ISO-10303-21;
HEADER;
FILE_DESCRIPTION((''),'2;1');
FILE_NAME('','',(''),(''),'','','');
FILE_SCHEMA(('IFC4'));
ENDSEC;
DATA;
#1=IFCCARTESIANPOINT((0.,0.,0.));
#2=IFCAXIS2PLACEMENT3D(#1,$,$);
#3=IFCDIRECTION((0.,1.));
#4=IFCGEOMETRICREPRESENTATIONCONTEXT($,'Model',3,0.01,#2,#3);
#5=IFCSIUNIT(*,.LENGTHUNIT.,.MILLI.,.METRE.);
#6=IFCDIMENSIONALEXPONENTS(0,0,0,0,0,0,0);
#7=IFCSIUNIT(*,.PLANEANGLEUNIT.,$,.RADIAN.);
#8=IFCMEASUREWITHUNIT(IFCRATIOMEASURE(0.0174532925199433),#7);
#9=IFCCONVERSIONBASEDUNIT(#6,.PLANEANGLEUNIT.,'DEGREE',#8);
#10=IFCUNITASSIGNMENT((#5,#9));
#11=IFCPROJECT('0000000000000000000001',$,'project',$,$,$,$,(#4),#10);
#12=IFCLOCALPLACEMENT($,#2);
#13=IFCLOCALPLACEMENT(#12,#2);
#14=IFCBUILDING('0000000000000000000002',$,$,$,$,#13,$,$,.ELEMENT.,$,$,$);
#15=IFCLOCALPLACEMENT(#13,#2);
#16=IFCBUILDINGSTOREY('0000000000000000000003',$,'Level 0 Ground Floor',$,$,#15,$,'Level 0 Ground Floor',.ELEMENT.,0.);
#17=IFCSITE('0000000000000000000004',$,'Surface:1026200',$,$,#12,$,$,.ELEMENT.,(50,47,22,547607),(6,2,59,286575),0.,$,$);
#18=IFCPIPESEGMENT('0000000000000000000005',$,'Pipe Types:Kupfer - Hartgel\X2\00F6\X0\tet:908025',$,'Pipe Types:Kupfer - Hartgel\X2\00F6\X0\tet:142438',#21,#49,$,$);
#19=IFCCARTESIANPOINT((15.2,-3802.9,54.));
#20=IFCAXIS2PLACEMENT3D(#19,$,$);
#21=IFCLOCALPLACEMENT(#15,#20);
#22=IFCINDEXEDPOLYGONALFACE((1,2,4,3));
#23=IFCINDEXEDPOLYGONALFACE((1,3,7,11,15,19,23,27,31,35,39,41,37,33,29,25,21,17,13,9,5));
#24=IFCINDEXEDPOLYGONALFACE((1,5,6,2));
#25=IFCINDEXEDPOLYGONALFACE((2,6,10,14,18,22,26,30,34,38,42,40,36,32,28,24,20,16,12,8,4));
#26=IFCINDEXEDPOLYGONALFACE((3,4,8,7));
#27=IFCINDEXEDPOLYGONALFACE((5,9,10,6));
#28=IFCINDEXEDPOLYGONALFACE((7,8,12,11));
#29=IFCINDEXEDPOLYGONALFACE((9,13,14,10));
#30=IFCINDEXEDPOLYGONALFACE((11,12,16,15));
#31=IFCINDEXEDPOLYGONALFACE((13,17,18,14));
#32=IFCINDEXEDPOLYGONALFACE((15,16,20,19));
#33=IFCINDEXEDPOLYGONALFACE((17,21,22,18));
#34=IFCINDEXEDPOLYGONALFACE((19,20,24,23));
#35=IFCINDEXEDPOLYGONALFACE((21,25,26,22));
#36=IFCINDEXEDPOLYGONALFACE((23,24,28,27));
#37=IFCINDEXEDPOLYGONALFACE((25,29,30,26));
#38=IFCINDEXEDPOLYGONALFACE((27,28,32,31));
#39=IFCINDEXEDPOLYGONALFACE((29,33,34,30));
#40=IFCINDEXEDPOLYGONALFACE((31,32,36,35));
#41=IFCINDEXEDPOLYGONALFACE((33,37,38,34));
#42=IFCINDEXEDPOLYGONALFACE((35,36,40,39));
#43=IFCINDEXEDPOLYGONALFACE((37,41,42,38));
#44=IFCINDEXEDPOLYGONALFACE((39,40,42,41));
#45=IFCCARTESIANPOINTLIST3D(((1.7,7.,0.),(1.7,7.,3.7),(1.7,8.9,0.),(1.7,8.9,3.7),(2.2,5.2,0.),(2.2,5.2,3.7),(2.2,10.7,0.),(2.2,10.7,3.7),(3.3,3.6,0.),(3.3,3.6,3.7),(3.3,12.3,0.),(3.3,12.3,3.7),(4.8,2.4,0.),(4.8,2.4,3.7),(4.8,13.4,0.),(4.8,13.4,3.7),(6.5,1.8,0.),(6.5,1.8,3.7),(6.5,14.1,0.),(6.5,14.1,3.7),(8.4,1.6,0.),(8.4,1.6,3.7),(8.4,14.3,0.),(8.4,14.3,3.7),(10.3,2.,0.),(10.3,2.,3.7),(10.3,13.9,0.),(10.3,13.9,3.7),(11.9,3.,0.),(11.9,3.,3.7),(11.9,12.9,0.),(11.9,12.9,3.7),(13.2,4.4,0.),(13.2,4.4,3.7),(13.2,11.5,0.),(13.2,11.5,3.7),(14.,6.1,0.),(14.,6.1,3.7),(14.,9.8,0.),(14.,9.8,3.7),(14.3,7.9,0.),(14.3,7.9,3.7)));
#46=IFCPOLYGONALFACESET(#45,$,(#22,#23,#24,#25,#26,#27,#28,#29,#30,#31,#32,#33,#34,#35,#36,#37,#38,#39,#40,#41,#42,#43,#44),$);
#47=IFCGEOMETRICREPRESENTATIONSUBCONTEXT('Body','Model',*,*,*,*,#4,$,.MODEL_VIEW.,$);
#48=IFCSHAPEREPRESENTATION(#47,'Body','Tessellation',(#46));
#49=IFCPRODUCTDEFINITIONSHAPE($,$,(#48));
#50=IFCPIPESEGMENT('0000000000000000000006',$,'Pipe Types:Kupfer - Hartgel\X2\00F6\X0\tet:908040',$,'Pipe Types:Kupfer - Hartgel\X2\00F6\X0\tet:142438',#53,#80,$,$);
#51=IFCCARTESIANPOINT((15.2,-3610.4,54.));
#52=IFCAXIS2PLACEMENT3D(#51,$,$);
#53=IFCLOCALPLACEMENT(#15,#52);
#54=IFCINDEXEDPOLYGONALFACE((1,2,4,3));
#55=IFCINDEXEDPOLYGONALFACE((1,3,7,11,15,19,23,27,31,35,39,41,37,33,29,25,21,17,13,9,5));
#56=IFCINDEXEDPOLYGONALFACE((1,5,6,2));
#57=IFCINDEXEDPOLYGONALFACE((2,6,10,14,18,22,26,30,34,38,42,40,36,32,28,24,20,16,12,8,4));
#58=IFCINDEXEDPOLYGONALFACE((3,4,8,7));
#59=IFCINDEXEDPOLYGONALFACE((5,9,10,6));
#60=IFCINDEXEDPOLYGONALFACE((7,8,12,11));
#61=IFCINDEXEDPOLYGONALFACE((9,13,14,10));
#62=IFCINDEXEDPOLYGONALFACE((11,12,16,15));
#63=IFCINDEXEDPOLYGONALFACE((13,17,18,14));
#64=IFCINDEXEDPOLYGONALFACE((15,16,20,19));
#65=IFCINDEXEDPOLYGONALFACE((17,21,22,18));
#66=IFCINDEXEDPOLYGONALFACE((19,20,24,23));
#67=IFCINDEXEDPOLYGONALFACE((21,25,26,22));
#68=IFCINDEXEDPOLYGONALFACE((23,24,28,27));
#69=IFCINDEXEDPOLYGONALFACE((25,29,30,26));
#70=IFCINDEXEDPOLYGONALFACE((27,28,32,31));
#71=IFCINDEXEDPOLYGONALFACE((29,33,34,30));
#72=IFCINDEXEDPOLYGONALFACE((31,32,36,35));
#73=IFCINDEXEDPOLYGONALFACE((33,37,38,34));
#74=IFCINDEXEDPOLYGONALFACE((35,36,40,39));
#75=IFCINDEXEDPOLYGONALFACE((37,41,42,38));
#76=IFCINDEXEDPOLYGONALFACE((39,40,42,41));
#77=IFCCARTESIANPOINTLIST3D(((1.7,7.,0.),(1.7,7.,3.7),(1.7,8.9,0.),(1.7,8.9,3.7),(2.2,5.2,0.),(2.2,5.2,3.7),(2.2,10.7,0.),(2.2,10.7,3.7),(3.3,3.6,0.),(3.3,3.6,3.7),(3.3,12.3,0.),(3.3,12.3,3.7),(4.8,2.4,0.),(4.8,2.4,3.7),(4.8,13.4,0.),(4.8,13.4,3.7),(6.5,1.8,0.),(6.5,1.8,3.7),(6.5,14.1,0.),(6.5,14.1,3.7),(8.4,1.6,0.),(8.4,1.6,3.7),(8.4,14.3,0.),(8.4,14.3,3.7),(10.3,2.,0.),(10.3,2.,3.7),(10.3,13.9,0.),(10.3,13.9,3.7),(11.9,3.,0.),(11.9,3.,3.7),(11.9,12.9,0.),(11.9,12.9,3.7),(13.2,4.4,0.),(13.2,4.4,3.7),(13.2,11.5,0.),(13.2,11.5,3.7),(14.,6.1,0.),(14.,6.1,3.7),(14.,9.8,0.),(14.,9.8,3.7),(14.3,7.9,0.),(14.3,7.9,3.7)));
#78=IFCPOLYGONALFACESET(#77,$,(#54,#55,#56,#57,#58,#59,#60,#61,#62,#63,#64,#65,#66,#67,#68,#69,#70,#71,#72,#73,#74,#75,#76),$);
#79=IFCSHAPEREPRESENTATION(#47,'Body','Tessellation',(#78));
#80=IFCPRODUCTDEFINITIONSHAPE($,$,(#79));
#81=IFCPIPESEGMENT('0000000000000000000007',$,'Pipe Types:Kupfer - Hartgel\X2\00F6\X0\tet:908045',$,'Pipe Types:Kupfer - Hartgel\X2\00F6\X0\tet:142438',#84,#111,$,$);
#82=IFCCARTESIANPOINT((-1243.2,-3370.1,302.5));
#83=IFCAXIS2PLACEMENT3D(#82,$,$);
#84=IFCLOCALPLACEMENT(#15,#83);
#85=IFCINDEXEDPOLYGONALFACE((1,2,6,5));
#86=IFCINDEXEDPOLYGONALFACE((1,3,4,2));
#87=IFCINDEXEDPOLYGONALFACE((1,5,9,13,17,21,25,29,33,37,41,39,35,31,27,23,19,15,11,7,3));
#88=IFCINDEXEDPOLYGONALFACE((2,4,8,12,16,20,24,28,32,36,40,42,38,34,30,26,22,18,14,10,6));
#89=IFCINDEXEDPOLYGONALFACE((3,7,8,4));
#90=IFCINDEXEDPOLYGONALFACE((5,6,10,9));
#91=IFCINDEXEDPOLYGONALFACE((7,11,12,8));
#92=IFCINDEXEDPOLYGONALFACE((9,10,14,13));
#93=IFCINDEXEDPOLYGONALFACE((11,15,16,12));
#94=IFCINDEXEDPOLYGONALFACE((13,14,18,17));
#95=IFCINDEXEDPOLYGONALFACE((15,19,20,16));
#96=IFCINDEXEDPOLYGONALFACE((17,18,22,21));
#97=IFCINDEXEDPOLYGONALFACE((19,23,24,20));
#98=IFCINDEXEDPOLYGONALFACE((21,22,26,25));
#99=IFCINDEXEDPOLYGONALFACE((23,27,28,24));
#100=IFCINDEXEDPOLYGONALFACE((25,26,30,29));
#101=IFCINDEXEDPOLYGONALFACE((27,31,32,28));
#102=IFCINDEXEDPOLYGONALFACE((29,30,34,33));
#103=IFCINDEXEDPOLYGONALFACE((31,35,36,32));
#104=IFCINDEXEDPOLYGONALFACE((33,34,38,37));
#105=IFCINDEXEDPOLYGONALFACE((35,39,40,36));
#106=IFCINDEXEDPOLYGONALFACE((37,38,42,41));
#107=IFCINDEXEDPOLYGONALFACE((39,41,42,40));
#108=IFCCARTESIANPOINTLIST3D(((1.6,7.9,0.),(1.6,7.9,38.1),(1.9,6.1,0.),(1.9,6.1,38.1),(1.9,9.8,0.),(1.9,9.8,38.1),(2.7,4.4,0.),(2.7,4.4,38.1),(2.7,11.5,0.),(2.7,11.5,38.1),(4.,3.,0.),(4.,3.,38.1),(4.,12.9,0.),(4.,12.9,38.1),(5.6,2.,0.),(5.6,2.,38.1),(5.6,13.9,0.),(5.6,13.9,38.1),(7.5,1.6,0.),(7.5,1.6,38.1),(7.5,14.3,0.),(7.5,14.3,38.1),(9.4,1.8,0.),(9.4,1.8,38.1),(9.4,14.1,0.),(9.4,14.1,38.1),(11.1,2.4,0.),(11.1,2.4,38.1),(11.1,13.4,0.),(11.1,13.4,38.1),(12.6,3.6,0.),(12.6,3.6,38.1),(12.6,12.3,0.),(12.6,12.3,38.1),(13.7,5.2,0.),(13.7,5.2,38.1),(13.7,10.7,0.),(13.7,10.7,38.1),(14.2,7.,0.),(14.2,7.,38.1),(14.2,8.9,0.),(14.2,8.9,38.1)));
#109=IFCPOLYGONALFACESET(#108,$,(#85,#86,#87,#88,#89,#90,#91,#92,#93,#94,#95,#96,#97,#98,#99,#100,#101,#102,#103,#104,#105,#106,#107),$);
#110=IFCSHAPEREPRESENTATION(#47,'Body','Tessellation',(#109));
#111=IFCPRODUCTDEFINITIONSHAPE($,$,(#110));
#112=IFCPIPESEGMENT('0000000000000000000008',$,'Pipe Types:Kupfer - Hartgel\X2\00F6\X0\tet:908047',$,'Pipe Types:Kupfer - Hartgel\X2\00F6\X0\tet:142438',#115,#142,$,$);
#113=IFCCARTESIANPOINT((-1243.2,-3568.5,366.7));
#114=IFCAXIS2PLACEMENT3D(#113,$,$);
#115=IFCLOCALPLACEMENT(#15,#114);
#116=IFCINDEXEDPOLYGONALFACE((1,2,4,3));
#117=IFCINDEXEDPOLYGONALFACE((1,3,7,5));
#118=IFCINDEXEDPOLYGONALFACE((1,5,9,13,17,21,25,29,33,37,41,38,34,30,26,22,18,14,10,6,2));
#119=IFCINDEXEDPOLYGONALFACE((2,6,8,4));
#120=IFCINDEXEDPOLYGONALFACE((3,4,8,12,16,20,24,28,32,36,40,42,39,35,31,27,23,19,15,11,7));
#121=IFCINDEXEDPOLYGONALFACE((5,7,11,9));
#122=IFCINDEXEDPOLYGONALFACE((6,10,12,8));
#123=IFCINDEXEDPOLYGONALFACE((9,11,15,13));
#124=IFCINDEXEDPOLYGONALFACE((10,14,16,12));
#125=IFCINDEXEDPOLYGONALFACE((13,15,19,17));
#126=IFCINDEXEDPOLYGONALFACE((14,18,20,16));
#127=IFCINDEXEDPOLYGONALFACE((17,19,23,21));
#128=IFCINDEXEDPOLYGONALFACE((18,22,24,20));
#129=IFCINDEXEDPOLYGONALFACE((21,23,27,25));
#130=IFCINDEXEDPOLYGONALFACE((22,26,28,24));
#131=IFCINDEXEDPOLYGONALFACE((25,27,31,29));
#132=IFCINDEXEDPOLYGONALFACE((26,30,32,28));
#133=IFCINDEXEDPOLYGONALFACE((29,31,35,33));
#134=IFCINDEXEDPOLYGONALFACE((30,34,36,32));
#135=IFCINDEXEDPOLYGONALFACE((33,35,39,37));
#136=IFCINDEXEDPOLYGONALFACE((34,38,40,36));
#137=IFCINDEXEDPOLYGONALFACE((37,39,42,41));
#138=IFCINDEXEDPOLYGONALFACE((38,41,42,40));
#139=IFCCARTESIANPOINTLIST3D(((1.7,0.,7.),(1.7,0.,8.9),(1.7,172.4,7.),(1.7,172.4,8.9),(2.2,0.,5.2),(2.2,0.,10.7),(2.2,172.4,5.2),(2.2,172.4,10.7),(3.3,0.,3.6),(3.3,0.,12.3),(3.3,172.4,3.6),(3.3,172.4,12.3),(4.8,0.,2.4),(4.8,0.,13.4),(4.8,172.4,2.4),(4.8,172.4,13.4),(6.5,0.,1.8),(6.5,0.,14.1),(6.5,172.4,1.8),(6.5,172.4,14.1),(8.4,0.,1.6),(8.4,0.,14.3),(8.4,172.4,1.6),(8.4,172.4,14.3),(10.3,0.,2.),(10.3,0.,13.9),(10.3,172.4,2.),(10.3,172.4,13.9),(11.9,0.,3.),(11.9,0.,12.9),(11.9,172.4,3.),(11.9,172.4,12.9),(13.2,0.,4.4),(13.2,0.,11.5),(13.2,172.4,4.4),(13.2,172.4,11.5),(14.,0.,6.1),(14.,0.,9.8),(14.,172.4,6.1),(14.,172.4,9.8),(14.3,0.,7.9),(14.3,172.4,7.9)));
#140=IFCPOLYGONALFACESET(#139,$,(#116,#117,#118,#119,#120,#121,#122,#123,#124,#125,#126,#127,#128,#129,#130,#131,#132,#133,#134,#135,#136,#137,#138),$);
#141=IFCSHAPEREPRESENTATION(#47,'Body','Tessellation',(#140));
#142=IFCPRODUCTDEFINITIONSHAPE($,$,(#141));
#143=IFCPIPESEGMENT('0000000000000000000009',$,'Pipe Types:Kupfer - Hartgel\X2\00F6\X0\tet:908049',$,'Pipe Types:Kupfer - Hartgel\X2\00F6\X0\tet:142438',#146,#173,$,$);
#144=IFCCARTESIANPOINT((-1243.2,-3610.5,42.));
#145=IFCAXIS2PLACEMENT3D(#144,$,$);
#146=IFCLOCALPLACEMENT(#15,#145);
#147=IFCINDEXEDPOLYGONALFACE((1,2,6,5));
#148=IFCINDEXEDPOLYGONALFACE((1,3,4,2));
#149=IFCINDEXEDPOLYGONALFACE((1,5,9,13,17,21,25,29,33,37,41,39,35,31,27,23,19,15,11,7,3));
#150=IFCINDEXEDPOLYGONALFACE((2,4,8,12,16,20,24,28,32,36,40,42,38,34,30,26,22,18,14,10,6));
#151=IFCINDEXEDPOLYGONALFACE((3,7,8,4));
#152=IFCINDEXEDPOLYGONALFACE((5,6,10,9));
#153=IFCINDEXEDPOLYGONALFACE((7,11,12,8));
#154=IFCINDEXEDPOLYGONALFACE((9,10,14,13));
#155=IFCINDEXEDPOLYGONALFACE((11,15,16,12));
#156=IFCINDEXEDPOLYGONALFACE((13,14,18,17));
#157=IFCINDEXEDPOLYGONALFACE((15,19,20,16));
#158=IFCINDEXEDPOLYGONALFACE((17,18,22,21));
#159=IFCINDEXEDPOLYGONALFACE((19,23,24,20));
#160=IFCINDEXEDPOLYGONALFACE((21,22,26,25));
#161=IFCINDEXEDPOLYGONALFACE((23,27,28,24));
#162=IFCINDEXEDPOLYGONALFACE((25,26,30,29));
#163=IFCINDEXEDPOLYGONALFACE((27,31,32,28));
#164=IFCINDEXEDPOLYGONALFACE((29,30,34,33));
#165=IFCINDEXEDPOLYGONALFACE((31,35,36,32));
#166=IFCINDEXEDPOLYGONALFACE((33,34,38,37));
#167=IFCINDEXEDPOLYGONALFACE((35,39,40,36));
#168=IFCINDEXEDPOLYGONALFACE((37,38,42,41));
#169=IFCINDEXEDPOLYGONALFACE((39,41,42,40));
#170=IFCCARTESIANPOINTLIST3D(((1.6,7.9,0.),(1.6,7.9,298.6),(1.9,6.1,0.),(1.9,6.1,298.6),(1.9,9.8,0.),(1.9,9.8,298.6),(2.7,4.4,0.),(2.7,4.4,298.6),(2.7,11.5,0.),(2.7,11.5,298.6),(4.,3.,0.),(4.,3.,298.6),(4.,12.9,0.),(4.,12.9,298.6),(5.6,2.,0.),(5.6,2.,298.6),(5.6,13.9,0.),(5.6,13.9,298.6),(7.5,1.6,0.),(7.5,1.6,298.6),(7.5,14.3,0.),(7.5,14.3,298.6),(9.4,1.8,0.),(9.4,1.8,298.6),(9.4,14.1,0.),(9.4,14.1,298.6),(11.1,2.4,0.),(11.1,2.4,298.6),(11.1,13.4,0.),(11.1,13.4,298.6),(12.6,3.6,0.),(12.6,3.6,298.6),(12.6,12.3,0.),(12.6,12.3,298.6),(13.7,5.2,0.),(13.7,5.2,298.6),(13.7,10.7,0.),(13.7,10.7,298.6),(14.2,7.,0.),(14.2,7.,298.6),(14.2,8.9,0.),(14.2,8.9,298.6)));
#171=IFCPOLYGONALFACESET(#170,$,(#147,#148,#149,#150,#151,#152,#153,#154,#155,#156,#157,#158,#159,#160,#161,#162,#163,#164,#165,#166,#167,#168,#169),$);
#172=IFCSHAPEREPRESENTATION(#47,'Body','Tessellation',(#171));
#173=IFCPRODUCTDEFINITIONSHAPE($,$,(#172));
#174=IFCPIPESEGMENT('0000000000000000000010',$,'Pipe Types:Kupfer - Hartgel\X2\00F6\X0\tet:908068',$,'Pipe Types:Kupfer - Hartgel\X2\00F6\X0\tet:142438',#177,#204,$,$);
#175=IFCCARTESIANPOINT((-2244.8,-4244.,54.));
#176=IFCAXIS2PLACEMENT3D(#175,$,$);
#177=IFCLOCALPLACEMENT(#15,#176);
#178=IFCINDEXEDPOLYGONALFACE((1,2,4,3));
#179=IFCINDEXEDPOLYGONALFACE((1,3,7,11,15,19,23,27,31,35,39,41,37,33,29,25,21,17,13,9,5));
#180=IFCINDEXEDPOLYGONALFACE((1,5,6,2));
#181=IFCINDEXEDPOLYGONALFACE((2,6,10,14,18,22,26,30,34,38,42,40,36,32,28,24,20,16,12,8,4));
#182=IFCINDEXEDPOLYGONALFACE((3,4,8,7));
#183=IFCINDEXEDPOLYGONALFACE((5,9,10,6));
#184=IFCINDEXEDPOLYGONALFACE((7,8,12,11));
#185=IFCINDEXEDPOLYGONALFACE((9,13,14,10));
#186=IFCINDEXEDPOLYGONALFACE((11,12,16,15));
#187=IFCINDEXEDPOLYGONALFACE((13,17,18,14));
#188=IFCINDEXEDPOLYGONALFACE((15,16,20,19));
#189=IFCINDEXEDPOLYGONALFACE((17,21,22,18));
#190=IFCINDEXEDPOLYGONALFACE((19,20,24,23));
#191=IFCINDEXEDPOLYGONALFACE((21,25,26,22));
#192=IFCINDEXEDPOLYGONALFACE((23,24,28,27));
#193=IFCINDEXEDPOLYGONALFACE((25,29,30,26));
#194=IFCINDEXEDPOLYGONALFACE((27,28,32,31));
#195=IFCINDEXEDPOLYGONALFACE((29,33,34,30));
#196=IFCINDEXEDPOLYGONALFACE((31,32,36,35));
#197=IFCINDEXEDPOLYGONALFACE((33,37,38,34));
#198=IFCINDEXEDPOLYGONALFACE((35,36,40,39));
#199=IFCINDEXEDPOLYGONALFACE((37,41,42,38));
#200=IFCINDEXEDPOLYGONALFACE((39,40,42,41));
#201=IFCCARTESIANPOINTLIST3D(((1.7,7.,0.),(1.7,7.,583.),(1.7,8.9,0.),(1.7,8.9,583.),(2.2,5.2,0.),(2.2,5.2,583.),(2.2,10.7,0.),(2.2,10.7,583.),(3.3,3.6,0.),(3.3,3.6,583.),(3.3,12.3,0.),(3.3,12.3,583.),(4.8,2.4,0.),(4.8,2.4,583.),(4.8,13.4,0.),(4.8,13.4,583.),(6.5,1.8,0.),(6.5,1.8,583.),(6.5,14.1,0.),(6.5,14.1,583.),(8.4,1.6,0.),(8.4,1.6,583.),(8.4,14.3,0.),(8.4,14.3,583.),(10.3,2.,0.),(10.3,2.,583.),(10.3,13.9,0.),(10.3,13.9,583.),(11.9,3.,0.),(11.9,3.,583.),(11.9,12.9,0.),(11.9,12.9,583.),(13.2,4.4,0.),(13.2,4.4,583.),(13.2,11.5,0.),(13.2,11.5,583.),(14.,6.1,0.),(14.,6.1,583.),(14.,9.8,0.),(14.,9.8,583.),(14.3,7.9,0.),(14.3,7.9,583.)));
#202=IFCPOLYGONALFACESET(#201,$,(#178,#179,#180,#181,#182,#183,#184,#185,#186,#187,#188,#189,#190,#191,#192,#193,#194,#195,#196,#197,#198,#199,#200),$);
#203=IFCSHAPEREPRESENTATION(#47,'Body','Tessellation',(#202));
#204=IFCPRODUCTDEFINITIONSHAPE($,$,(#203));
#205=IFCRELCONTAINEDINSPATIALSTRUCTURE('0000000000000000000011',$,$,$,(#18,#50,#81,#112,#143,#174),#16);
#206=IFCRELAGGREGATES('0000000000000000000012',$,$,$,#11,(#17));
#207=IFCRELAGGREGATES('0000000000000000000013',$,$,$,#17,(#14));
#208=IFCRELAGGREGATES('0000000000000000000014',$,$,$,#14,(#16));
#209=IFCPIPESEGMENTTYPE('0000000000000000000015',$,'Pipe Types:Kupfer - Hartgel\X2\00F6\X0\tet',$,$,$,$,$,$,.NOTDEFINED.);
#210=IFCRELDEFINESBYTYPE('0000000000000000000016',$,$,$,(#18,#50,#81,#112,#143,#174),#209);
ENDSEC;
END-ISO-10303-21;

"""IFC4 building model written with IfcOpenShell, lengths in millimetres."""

from ifc_helpers import new_model, entity, si_unit, converted_unit, direction, frame, frame_2d, origin, origin_2d_with_axis, place, context, subcontext, project, spatial, circle, extrude, type_object, element, save


model = new_model("IFC4")

# Units and contexts
model_context = context("Model", 3, precision=0.01, world=origin(), true_north=direction((0.0, 1.0)))
body_context = subcontext(model_context, "Body", "Model", "MODEL_VIEW")
ifc_project = project(units=[si_unit("LENGTHUNIT", "METRE", prefix="MILLI"), converted_unit("PLANEANGLEUNIT", "DEGREE", entity("IfcRatioMeasure", 0.0174532925199433), si_unit("PLANEANGLEUNIT", "RADIAN"), dimensions=[0, 0, 0, 0, 0, 0, 0])], contexts=[model_context])

# Site, building, storey
site_placement = place(None, origin())
site = spatial("IfcSite", under=ifc_project, at=site_placement, Name="Surface:1026200", CompositionType="ELEMENT", RefLatitude=(50, 47, 22, 547607), RefLongitude=(6, 2, 59, 286575), RefElevation=0.0)
building_placement = place(site_placement, origin())
building = spatial("IfcBuilding", under=site, at=building_placement, CompositionType="ELEMENT")
storey_placement = place(building_placement, origin())
storey = spatial("IfcBuildingStorey", under=building, at=storey_placement, Name="Level 0 Ground Floor", LongName="Level 0 Ground Floor", CompositionType="ELEMENT", Elevation=0.0)

# Pipe segments
pipe_segment_type = type_object("IfcPipeSegmentType", Name="Pipe Types:Kupfer - Hartgelötet", PredefinedType="NOTDEFINED")
pipe_segment_1_placement = place(storey_placement, frame((15.2, -3802.9, 54.0)))
element("IfcPipeSegment", 1, at=pipe_segment_1_placement, inside=storey, type_object=pipe_segment_type, Name="Pipe Types:Kupfer - Hartgelötet:908025", ObjectType="Pipe Types:Kupfer - Hartgelötet:142438", context=body_context, shape_type="SweptSolid", body=[
    extrude(circle(Radius=6.3, at=frame_2d((0.0, 0.0), x_axis=(1.0, 0.0))), frame((7.9, 7.9, 0.0)), (0.0, 0.0, 1.0), 3.7),
])
pipe_segment_2_placement = place(storey_placement, frame((15.2, -3610.4, 54.0)))
element("IfcPipeSegment", 2, at=pipe_segment_2_placement, inside=storey, type_object=pipe_segment_type, Name="Pipe Types:Kupfer - Hartgelötet:908040", ObjectType="Pipe Types:Kupfer - Hartgelötet:142438", context=body_context, shape_type="SweptSolid", body=[
    extrude(circle(Radius=6.3, at=frame_2d((0.0, 0.0), x_axis=(1.0, 0.0))), frame((7.9, 7.9, 0.0)), (0.0, 0.0, 1.0), 3.7),
])
pipe_segment_3_placement = place(storey_placement, frame((-1243.2, -3370.1, 302.5)))
element("IfcPipeSegment", 3, at=pipe_segment_3_placement, inside=storey, type_object=pipe_segment_type, Name="Pipe Types:Kupfer - Hartgelötet:908045", ObjectType="Pipe Types:Kupfer - Hartgelötet:142438", context=body_context, shape_type="SweptSolid", body=[
    extrude(circle(Radius=6.3, at=origin_2d_with_axis()), frame((7.9, 7.9, 0.0), z_axis=(0.0, 0.0, 1.0), x_axis=(-1.0, 0.0, 0.0)), (0.0, 0.0, 1.0), 38.1),
])
pipe_segment_4_placement = place(storey_placement, frame((-1243.2, -3568.5, 366.7)))
element("IfcPipeSegment", 4, at=pipe_segment_4_placement, inside=storey, type_object=pipe_segment_type, Name="Pipe Types:Kupfer - Hartgelötet:908047", ObjectType="Pipe Types:Kupfer - Hartgelötet:142438", context=body_context, shape_type="SweptSolid", body=[
    extrude(circle(Radius=6.3, at=frame_2d((0.0, 0.0), x_axis=(1.0, 0.0))), frame((7.9, 0.0, 7.9), z_axis=(0.0, 1.0, 0.0), x_axis=(1.0, 0.0, 0.0)), (0.0, 0.0, 1.0), 172.4),
])
pipe_segment_5_placement = place(storey_placement, frame((-1243.2, -3610.5, 42.0)))
element("IfcPipeSegment", 5, at=pipe_segment_5_placement, inside=storey, type_object=pipe_segment_type, Name="Pipe Types:Kupfer - Hartgelötet:908049", ObjectType="Pipe Types:Kupfer - Hartgelötet:142438", context=body_context, shape_type="SweptSolid", body=[
    extrude(circle(Radius=6.3, at=frame_2d((0.0, 0.0), x_axis=(1.0, 0.0))), frame((7.9, 7.9, 0.0), z_axis=(0.0, 0.0, 1.0), x_axis=(-1.0, 0.0, 0.0)), (0.0, 0.0, 1.0), 298.6),
])
pipe_segment_6_placement = place(storey_placement, frame((-2244.8, -4244.0, 54.0)))
element("IfcPipeSegment", 6, at=pipe_segment_6_placement, inside=storey, type_object=pipe_segment_type, Name="Pipe Types:Kupfer - Hartgelötet:908068", ObjectType="Pipe Types:Kupfer - Hartgelötet:142438", context=body_context, shape_type="SweptSolid", body=[
    extrude(circle(Radius=6.3, at=frame_2d((0.0, 0.0), x_axis=(1.0, 0.0))), frame((7.9, 7.9, 0.0)), (0.0, 0.0, 1.0), 583.0),
])

save(model, "model.ifc")
